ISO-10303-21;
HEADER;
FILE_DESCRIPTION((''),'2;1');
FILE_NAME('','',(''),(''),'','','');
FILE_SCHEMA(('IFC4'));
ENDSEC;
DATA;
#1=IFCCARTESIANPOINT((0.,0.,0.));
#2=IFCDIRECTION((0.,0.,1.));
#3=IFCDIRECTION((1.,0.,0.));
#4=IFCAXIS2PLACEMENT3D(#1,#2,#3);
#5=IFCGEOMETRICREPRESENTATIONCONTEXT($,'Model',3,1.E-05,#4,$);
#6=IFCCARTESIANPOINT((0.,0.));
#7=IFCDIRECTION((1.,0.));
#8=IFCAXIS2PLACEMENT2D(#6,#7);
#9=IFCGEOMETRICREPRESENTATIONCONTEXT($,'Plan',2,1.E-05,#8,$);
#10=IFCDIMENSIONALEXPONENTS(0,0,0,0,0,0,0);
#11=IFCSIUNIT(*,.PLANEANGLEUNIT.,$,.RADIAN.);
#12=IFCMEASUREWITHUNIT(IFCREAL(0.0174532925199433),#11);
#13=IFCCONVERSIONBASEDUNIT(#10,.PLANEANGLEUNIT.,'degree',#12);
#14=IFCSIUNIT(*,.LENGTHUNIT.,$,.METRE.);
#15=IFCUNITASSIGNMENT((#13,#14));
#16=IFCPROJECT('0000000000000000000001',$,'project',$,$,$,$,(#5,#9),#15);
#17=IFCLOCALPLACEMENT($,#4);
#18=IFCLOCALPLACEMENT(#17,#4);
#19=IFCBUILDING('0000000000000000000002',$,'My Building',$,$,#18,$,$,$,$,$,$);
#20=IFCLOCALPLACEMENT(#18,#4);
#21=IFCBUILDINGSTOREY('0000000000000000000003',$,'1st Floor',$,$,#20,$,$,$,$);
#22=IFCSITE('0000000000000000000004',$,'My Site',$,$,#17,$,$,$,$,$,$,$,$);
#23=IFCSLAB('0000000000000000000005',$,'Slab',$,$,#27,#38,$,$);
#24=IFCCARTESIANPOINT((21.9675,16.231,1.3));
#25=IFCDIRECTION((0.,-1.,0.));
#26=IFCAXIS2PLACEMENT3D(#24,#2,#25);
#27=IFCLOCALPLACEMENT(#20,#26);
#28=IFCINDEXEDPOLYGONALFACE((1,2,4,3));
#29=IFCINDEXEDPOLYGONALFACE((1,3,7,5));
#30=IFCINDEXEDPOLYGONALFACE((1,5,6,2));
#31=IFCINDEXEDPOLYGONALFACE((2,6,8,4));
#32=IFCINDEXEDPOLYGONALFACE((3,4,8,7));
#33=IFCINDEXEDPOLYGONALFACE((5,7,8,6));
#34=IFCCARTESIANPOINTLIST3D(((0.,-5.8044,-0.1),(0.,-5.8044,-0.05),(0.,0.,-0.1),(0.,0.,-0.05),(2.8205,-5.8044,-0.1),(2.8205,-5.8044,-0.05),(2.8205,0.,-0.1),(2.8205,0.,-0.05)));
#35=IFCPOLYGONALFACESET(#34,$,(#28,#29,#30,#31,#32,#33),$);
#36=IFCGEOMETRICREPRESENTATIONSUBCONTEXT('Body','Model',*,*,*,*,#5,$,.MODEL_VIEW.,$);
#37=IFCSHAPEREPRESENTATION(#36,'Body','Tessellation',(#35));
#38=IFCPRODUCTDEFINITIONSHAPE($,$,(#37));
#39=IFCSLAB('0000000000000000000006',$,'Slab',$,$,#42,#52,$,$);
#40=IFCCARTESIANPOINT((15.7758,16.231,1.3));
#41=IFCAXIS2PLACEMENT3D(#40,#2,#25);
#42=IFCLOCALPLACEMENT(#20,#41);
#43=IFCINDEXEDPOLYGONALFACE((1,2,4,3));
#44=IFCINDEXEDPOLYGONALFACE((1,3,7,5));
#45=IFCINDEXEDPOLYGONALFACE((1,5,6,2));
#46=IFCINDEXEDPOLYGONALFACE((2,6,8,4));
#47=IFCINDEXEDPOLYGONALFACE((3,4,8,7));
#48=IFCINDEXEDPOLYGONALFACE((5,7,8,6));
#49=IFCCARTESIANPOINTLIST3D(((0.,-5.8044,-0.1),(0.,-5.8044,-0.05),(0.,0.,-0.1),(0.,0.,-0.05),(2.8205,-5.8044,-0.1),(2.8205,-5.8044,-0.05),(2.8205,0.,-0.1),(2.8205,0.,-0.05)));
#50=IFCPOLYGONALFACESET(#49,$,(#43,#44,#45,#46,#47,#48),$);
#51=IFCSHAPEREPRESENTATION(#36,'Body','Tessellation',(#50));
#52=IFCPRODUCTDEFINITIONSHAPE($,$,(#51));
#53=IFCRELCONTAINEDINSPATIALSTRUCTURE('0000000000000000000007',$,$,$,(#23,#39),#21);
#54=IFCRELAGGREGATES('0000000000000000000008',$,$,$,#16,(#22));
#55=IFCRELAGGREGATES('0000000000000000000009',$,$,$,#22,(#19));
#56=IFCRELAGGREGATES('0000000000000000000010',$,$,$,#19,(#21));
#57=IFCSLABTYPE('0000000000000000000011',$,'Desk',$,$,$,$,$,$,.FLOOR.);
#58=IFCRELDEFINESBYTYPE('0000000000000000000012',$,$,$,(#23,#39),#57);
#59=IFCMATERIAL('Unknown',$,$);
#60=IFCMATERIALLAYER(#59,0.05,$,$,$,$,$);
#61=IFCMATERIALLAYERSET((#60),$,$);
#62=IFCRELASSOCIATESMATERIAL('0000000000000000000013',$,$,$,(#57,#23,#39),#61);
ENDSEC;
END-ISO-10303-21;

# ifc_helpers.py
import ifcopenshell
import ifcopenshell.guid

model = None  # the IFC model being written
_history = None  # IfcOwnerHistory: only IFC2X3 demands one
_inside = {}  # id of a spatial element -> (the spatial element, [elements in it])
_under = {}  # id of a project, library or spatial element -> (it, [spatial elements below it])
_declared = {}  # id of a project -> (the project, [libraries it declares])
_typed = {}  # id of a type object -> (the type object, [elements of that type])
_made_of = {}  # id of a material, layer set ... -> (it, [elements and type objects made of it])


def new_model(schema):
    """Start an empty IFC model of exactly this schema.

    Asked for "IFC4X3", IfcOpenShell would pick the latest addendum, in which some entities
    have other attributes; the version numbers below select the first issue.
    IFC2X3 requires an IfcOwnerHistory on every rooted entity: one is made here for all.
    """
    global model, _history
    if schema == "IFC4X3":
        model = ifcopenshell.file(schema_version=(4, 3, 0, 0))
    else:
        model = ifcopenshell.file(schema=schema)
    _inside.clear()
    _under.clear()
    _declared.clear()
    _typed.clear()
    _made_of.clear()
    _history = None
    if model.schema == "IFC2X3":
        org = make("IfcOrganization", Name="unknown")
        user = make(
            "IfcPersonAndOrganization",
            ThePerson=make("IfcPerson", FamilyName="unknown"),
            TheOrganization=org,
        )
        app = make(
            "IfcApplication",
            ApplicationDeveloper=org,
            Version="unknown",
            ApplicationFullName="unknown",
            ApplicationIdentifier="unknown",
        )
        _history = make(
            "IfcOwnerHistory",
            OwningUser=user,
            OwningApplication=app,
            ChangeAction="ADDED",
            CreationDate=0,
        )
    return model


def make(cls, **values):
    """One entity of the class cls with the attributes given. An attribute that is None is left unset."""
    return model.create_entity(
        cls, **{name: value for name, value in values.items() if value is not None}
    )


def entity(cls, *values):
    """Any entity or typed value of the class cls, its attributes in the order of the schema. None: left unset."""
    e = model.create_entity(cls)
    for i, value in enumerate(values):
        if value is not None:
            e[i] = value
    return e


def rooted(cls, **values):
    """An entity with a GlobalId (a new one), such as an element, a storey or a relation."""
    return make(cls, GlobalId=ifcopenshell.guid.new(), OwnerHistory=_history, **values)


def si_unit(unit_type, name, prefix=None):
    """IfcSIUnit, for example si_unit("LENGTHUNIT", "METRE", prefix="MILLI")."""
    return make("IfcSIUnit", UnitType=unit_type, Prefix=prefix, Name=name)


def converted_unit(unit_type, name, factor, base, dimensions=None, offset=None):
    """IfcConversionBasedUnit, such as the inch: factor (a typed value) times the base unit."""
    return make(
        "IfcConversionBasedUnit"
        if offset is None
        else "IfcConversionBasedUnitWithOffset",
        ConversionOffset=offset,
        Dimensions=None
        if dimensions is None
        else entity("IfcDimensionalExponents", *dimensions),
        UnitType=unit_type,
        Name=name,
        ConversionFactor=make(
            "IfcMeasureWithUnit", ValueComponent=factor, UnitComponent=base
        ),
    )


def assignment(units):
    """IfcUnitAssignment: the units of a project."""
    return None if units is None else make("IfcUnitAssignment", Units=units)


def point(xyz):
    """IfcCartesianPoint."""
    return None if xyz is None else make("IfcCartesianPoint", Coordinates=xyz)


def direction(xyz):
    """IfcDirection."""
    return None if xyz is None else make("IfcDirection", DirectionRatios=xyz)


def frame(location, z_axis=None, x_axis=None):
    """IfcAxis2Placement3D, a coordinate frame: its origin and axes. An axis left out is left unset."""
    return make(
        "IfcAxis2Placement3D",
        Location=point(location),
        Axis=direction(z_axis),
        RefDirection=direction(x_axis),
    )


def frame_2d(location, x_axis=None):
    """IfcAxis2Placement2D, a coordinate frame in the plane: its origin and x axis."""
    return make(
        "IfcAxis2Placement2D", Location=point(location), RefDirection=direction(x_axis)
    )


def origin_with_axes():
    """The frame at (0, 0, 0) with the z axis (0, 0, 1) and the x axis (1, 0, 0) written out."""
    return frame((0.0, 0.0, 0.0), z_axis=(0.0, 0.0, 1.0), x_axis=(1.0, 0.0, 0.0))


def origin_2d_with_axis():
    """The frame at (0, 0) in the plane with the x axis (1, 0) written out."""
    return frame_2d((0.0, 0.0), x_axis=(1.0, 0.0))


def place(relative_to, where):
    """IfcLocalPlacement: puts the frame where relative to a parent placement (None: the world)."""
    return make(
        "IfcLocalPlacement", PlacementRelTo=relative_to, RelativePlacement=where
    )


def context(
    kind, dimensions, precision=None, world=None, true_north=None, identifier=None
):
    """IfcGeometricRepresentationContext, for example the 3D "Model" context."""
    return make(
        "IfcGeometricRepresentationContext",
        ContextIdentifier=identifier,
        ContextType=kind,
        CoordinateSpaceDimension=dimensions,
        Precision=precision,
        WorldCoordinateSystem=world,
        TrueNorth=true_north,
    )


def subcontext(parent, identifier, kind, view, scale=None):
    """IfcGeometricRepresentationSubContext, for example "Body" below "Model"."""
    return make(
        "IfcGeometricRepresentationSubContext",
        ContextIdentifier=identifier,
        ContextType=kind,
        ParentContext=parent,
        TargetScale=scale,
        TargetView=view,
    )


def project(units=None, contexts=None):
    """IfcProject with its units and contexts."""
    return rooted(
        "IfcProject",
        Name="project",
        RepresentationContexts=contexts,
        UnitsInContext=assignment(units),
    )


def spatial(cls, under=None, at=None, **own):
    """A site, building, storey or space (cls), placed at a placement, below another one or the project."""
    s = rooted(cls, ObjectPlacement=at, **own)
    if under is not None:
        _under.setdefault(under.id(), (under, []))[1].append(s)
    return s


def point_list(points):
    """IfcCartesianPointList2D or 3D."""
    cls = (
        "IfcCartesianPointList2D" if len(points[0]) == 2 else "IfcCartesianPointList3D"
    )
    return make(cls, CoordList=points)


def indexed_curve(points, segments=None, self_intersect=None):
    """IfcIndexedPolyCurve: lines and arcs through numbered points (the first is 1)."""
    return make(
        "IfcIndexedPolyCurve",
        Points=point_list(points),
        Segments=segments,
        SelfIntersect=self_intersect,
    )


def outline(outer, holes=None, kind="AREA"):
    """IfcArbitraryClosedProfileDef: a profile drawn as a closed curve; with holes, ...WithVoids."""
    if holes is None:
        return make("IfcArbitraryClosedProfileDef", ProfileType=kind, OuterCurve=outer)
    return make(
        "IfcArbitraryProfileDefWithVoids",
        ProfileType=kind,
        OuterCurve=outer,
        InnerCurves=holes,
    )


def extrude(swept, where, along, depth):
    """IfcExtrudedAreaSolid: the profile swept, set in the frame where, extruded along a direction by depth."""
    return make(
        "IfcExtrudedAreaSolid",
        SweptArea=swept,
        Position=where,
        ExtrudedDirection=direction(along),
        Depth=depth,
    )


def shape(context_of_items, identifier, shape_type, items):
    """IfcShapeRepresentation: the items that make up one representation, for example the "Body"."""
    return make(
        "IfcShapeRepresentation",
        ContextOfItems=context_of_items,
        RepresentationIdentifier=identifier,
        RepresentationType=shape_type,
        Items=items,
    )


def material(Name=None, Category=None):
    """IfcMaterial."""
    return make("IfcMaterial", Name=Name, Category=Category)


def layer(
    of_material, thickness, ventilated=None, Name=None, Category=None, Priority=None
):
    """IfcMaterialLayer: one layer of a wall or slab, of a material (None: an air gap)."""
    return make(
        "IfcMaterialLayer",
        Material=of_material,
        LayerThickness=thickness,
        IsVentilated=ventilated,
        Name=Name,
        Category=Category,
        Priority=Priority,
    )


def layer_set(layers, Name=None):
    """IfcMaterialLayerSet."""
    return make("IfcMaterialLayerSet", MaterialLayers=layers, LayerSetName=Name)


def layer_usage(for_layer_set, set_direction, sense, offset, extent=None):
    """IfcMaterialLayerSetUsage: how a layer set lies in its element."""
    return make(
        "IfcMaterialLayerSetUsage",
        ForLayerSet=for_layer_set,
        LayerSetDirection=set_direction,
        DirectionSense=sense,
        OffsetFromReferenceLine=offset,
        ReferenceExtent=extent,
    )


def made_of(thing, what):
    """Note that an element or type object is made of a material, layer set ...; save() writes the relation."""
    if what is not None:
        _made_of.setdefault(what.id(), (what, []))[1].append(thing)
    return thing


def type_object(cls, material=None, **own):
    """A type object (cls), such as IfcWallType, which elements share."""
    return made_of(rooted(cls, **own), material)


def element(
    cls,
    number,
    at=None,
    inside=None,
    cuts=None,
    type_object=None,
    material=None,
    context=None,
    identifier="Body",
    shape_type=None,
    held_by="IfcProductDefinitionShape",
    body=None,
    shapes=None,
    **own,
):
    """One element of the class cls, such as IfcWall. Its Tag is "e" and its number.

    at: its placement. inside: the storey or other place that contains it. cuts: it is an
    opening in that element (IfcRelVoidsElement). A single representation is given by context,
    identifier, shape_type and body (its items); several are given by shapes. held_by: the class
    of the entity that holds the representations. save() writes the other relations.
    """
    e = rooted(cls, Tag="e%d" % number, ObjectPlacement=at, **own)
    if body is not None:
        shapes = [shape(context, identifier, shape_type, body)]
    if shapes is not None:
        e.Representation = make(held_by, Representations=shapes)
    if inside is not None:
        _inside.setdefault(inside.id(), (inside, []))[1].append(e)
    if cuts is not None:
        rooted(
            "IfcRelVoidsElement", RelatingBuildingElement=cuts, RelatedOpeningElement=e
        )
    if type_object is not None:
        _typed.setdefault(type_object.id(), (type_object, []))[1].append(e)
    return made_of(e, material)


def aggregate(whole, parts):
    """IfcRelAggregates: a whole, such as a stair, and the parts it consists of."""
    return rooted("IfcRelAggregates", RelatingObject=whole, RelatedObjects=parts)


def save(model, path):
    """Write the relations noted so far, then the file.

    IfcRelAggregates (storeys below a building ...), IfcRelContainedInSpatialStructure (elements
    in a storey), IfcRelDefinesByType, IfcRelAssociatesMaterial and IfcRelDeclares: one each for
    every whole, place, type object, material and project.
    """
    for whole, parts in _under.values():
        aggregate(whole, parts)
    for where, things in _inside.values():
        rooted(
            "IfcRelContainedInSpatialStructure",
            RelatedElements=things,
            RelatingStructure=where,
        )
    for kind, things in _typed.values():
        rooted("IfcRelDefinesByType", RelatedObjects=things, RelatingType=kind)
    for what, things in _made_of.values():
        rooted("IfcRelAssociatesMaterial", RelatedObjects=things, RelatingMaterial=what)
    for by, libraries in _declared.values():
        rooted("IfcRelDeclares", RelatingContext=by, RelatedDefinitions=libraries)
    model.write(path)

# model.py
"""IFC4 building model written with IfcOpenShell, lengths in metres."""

from ifc_helpers import new_model, entity, si_unit, converted_unit, frame, origin_with_axes, origin_2d_with_axis, place, context, subcontext, project, spatial, indexed_curve, outline, extrude, material, layer, layer_set, layer_usage, type_object, element, save


model = new_model("IFC4")

# Units and contexts
model_context = context("Model", 3, precision=1e-05, world=origin_with_axes())
plan_context = context("Plan", 2, precision=1e-05, world=origin_2d_with_axis())
body_context_1 = subcontext(model_context, "Body", "Model", "MODEL_VIEW")
ifc_project = project(units=[converted_unit("PLANEANGLEUNIT", "degree", entity("IfcReal", 0.0174532925199433), si_unit("PLANEANGLEUNIT", "RADIAN"), dimensions=[0, 0, 0, 0, 0, 0, 0]), si_unit("LENGTHUNIT", "METRE")], contexts=[model_context, plan_context])

# Site, building, storey
site_placement = place(None, origin_with_axes())
site = spatial("IfcSite", under=ifc_project, at=site_placement, Name="My Site")
building_placement = place(site_placement, origin_with_axes())
building = spatial("IfcBuilding", under=site, at=building_placement, Name="My Building")
storey_placement = place(building_placement, origin_with_axes())
storey = spatial("IfcBuildingStorey", under=building, at=storey_placement, Name="1st Floor")

# Shared definitions
ifc_material = material(Name="Unknown")

# Slabs
ifc_layer_1 = layer(ifc_material, 0.05)
ifc_layer_set_1 = layer_set([ifc_layer_1])
slab_type_1 = type_object("IfcSlabType", Name="Desk", PredefinedType="FLOOR", material=ifc_layer_set_1)
ifc_layer_usage_1 = layer_usage(ifc_layer_set_1, "AXIS3", "POSITIVE", -0.1)
slab_1_placement = place(storey_placement, frame((21.9675, 16.231, 1.3), z_axis=(0.0, 0.0, 1.0), x_axis=(0.0, -1.0, 0.0)))
element("IfcSlab", 1, at=slab_1_placement, inside=storey, type_object=slab_type_1, material=ifc_layer_usage_1, Name="Slab", context=body_context_1, shape_type="SweptSolid", body=[
    extrude(outline(indexed_curve([(0.0, 0.0), (2.8205, 0.0), (2.8205, -5.8044), (0.0, -5.8044), (0.0, 0.0)])), frame((0.0, 0.0, -0.1), z_axis=(0.0, 0.0, 1.0), x_axis=(1.0, 0.0, 0.0)), (0.0, 0.0, 1.0), 0.05),
])
ifc_layer_usage_2 = layer_usage(ifc_layer_set_1, "AXIS3", "POSITIVE", -0.1)
slab_2_placement = place(storey_placement, frame((15.7758, 16.231, 1.3), z_axis=(0.0, 0.0, 1.0), x_axis=(0.0, -1.0, 0.0)))
element("IfcSlab", 2, at=slab_2_placement, inside=storey, type_object=slab_type_1, material=ifc_layer_usage_2, Name="Slab", context=body_context_1, shape_type="SweptSolid", body=[
    extrude(outline(indexed_curve([(0.0, 0.0), (2.8205, 0.0), (2.8205, -5.8044), (0.0, -5.8044), (0.0, 0.0)])), frame((0.0, 0.0, -0.1), z_axis=(0.0, 0.0, 1.0), x_axis=(1.0, 0.0, 0.0)), (0.0, 0.0, 1.0), 0.05),
])

save(model, "model.ifc")
